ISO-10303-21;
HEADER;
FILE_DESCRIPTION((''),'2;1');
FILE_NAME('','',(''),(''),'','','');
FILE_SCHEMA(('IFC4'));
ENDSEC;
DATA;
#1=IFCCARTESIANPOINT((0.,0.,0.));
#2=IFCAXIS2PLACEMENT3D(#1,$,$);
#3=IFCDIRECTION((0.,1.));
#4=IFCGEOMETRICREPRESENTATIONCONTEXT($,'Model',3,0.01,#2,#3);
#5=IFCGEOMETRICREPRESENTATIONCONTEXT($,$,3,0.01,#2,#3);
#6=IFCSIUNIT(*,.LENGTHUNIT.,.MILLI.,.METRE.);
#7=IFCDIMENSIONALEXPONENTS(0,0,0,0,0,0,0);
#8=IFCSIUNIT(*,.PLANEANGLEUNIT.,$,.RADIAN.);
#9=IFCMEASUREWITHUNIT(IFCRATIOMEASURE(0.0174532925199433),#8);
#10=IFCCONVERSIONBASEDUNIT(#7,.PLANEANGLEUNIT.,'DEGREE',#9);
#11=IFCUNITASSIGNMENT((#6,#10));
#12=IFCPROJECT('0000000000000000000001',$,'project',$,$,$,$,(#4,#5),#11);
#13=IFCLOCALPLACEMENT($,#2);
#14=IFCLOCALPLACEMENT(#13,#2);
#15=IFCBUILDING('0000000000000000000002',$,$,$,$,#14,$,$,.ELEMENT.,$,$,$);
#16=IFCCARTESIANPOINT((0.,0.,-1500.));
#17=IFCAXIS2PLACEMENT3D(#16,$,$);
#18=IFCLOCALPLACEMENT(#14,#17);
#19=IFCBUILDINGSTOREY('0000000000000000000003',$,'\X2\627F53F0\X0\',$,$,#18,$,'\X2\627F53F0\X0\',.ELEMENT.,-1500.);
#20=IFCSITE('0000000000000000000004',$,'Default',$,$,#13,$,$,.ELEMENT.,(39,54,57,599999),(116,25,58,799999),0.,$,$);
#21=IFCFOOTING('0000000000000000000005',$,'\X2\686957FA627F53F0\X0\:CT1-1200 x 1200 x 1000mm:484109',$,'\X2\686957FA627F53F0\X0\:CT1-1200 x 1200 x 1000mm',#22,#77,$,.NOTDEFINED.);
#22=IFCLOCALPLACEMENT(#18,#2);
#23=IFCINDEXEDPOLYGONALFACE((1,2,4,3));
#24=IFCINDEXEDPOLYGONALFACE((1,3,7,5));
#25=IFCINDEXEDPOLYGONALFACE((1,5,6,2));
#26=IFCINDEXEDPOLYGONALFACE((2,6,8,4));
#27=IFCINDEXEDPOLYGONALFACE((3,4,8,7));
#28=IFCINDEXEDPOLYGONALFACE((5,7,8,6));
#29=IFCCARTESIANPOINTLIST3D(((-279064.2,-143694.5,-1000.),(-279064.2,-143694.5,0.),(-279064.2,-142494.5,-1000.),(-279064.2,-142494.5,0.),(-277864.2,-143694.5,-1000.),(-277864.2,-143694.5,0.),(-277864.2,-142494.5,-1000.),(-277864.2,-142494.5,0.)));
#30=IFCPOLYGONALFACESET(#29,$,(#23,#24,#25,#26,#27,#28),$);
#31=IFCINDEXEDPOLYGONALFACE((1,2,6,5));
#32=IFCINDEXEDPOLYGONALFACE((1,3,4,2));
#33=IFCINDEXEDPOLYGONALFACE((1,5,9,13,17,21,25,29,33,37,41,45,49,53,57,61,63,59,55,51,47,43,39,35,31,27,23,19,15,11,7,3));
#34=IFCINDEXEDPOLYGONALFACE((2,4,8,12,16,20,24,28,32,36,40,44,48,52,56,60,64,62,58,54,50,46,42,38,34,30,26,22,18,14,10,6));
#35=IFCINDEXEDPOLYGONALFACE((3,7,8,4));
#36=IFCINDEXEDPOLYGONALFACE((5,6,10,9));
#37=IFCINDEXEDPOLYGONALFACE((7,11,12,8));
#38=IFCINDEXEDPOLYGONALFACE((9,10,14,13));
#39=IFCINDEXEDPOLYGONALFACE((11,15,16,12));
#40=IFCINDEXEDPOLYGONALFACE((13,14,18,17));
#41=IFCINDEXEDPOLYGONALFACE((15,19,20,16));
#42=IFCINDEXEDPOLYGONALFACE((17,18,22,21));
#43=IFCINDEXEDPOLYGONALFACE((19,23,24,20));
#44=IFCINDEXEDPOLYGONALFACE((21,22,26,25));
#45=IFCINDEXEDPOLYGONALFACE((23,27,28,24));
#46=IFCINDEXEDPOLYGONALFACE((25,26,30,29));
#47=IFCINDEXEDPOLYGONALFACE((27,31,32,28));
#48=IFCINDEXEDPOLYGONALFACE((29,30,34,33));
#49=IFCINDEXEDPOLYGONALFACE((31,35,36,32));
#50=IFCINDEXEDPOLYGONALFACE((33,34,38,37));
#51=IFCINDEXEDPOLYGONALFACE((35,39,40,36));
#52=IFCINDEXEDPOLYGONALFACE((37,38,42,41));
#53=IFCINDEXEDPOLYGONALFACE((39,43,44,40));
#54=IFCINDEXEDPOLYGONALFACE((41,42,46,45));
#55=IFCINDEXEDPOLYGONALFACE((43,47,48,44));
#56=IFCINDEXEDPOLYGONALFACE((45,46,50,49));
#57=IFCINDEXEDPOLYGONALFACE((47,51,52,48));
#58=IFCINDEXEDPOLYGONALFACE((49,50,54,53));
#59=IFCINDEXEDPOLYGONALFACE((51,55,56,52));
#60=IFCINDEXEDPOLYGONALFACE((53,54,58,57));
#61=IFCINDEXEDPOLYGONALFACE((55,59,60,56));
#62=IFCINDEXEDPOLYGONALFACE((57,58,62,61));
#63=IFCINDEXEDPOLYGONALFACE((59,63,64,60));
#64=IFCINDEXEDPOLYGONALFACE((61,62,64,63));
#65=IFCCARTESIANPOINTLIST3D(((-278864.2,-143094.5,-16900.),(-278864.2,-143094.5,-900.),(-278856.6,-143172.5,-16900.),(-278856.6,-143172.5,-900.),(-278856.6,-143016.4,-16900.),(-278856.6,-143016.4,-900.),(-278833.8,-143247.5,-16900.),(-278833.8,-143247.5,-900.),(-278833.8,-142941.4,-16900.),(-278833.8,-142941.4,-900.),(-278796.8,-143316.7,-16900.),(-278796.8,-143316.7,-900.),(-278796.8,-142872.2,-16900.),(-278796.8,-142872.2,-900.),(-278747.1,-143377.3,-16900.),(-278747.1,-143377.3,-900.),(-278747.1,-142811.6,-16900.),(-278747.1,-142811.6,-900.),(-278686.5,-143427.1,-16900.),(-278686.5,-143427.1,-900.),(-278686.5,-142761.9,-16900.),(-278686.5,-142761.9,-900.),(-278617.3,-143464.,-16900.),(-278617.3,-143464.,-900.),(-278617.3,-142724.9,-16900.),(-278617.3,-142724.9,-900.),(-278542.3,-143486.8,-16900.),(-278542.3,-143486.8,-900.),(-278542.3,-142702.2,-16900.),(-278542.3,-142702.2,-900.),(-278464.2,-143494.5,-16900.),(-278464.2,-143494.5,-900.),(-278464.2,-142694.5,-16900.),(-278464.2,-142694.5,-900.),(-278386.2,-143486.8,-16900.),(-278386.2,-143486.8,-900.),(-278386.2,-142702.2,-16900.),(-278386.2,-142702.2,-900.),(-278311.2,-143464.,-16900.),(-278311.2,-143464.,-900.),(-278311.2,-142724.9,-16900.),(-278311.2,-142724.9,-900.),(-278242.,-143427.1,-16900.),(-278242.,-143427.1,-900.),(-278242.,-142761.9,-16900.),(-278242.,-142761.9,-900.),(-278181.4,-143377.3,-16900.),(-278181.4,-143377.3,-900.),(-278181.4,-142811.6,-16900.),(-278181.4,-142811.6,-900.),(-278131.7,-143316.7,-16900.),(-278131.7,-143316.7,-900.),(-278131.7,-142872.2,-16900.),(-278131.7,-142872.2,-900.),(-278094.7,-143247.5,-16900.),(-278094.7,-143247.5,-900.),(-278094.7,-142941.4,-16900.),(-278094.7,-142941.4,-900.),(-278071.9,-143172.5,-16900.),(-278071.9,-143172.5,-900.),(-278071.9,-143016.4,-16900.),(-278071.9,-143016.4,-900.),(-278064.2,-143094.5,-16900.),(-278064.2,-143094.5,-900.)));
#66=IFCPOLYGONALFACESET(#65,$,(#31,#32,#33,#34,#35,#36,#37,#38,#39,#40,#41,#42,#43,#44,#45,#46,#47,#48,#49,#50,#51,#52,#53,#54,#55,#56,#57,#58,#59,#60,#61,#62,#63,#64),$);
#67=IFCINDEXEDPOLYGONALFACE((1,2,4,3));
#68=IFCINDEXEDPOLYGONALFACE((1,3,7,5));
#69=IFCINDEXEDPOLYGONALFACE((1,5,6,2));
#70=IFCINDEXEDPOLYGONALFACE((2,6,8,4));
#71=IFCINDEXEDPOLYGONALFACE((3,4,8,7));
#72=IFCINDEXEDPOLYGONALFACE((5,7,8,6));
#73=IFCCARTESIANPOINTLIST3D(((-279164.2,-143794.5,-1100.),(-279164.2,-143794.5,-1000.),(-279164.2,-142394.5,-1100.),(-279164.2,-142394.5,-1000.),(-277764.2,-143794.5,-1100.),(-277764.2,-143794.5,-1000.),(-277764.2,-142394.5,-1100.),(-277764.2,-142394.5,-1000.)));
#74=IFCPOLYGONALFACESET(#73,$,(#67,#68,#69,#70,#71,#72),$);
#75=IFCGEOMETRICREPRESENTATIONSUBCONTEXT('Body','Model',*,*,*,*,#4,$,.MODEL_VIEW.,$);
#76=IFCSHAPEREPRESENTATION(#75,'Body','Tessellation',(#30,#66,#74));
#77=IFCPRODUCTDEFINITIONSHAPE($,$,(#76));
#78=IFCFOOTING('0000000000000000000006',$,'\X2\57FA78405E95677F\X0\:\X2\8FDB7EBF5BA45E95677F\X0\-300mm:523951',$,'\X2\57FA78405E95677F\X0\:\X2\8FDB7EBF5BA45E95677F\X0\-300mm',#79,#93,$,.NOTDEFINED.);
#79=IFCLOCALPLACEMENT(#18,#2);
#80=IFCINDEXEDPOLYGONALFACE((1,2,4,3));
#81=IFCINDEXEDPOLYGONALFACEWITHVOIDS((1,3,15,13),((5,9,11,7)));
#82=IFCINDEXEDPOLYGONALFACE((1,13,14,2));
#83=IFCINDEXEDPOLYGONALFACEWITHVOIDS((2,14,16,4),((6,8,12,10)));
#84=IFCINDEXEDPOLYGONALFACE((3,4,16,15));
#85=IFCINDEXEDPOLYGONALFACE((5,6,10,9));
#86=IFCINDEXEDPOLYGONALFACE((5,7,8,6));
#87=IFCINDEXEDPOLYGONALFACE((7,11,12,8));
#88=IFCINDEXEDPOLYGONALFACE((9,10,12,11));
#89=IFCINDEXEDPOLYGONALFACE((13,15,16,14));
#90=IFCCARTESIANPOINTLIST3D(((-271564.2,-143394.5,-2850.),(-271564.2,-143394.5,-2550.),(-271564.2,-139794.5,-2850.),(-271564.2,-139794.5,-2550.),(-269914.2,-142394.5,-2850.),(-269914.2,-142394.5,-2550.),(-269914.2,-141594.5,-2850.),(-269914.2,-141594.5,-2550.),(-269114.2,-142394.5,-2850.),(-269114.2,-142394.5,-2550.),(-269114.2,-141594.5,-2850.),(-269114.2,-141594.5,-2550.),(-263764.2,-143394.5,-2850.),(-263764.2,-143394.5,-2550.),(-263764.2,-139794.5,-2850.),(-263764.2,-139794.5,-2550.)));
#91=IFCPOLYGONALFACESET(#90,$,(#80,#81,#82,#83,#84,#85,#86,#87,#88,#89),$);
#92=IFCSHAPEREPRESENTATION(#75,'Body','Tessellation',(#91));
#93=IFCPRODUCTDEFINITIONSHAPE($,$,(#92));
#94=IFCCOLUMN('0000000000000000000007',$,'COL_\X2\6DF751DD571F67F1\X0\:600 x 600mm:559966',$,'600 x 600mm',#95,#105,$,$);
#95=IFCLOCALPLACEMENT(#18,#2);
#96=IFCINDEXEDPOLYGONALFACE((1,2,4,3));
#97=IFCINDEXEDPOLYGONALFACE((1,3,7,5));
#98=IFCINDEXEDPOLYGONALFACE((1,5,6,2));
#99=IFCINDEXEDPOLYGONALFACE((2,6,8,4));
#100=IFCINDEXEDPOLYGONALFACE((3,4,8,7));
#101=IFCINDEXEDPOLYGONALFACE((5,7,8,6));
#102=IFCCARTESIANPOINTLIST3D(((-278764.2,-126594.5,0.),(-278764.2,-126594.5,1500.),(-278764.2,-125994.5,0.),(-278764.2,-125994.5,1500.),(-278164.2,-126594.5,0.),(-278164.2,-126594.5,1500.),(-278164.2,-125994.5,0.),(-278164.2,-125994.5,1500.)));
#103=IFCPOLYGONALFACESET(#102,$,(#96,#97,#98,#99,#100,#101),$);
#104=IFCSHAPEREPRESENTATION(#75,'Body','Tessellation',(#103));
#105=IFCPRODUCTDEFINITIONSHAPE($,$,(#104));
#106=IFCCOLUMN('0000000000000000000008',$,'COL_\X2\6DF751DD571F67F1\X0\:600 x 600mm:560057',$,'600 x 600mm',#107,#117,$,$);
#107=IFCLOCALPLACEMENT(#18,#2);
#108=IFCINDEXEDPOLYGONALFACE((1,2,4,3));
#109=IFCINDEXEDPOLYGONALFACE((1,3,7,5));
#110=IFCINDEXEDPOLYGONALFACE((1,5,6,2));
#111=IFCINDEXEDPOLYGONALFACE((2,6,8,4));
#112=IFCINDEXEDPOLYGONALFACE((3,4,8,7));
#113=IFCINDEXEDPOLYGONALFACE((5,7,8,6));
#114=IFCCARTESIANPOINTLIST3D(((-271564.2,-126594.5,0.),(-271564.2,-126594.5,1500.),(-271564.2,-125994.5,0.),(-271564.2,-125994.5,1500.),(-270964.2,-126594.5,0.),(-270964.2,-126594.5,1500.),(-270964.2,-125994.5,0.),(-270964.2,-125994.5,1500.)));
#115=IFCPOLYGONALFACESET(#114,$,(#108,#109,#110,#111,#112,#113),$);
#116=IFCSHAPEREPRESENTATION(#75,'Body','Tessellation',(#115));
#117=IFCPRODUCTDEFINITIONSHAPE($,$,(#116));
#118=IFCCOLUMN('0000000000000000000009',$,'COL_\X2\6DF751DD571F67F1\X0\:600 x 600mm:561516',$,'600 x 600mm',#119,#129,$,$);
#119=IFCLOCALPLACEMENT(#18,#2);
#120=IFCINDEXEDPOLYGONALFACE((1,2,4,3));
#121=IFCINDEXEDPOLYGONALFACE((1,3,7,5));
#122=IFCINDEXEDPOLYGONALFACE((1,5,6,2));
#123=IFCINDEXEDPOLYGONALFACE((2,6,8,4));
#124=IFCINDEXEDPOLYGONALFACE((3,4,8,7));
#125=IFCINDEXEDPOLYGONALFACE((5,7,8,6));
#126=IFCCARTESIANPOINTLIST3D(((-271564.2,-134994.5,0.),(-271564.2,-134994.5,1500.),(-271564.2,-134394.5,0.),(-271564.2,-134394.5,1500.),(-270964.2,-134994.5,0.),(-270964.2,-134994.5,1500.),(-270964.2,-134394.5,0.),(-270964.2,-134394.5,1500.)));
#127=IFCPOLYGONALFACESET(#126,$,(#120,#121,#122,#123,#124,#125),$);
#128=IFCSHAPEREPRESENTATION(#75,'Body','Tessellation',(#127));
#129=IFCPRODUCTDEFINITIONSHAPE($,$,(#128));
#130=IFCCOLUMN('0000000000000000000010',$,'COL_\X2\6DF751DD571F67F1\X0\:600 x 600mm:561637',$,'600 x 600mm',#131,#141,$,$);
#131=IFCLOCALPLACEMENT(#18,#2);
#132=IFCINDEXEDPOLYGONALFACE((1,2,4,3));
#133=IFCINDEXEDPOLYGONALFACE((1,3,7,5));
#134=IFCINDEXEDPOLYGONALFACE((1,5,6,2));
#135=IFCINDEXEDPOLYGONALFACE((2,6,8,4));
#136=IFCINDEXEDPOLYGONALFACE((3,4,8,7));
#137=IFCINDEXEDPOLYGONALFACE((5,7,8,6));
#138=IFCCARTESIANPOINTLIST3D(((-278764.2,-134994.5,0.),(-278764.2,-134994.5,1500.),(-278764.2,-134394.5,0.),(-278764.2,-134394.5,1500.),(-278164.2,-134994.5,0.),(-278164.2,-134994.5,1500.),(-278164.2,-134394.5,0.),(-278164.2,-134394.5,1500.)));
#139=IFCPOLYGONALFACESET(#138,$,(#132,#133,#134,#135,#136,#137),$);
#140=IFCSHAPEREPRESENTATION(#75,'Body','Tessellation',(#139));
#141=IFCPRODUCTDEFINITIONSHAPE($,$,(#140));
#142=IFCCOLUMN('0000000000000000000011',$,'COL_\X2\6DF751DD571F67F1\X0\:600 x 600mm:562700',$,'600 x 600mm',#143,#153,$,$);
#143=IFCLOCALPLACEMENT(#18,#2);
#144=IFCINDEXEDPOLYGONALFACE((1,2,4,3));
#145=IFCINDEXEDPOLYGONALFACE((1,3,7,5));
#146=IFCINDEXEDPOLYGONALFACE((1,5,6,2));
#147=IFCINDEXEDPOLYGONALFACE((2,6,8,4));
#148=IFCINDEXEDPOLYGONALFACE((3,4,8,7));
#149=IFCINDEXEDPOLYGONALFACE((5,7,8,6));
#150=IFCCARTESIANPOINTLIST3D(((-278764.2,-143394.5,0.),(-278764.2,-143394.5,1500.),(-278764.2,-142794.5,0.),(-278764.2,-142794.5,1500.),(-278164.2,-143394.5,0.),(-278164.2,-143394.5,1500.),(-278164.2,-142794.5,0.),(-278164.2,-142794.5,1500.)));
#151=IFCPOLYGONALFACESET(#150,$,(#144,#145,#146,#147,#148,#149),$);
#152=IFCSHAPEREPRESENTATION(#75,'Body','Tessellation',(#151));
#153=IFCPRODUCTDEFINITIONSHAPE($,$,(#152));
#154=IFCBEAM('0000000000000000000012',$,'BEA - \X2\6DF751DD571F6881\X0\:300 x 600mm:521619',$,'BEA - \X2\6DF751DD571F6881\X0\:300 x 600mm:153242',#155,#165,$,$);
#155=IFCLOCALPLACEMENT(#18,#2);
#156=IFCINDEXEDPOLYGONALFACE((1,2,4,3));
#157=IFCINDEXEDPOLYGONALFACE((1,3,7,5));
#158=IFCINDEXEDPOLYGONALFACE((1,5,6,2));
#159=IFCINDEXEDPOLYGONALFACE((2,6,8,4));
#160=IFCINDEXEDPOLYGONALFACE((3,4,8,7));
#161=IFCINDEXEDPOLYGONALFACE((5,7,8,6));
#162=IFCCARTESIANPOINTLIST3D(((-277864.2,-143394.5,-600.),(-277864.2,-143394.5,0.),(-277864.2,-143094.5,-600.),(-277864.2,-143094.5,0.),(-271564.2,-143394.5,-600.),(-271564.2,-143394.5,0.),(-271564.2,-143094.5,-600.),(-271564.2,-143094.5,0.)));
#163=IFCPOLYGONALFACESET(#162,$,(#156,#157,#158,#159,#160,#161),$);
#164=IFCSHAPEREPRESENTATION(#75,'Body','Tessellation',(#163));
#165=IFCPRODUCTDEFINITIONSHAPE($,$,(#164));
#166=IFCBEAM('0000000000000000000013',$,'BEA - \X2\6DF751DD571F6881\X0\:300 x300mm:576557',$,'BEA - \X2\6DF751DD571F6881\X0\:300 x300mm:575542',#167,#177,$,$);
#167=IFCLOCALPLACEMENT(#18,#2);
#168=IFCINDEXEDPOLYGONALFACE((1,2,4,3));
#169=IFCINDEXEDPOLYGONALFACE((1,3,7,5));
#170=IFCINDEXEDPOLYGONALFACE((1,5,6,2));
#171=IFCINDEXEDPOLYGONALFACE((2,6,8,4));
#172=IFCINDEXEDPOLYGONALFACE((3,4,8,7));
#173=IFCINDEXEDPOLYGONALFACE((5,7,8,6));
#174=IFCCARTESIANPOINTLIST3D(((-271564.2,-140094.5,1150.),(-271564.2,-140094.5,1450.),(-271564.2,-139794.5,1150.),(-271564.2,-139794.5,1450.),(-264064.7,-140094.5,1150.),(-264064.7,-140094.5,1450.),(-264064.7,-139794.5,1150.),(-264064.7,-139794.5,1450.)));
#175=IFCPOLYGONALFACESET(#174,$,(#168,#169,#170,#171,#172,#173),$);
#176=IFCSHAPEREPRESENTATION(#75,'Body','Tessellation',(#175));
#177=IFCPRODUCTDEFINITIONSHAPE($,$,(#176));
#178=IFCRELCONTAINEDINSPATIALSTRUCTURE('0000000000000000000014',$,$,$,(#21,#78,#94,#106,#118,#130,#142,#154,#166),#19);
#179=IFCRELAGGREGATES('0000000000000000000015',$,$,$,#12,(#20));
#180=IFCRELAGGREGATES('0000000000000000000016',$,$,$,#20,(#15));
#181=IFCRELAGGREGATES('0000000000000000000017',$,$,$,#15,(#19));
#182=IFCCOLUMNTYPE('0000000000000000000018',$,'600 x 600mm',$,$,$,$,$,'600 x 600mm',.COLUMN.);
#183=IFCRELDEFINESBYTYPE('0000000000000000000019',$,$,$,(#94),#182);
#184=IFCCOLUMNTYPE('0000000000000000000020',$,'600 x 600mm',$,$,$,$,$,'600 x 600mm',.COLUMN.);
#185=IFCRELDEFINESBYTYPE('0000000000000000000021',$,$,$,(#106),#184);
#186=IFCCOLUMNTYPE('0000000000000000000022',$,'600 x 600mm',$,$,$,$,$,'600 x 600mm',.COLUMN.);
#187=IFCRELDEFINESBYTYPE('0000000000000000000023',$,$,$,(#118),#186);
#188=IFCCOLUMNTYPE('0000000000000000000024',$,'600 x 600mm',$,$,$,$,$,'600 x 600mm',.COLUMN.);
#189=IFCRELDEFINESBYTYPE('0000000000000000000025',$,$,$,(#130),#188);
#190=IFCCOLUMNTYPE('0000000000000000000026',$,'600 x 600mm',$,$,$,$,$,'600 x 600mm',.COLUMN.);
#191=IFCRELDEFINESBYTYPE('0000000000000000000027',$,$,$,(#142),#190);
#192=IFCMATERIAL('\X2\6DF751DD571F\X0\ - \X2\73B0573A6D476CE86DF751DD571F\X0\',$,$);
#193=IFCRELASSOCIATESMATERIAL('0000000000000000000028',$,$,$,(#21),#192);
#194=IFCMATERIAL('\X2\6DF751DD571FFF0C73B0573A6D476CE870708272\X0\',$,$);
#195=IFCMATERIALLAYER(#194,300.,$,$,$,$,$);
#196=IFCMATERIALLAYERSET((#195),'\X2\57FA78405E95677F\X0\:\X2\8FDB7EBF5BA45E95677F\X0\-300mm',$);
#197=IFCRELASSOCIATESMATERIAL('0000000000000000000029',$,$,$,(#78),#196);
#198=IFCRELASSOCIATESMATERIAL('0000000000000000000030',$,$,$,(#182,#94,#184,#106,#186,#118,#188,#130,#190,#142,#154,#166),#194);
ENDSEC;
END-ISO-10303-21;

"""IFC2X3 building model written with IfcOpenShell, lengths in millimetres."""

from ifc_helpers import new_model, entity, si_unit, converted_unit, direction, frame, frame_2d, origin, origin_2d_with_axis, place, context, subcontext, project, spatial, rectangle, circle, extrude, source, transform, mapped, material, layer, layer_set, layer_usage, type_object, type_shapes, element, save


model = new_model("IFC2X3")

# Units and contexts
model_context = context("Model", 3, precision=0.01, world=origin(), true_north=direction((0.0, 1.0)))
context_of_model = context(None, 3, precision=0.01, world=origin(), true_north=direction((0.0, 1.0)))
body_context = subcontext(model_context, "Body", "Model", "MODEL_VIEW")
ifc_project = project(units=[si_unit("LENGTHUNIT", "METRE", prefix="MILLI"), converted_unit("PLANEANGLEUNIT", "DEGREE", entity("IfcRatioMeasure", 0.0174532925199433), si_unit("PLANEANGLEUNIT", "RADIAN"), dimensions=[0, 0, 0, 0, 0, 0, 0])], contexts=[model_context, context_of_model])

# Site, building, storey
site_placement = place(None, origin())
site = spatial("IfcSite", under=ifc_project, at=site_placement, Name="Default", CompositionType="ELEMENT", RefLatitude=(39, 54, 57, 599999), RefLongitude=(116, 25, 58, 799999), RefElevation=0.0)
building_placement = place(site_placement, origin())
building = spatial("IfcBuilding", under=site, at=building_placement, CompositionType="ELEMENT")
storey_placement = place(building_placement, frame((0.0, 0.0, -1500.0)))
storey = spatial("IfcBuildingStorey", under=building, at=storey_placement, Name="承台", LongName="承台", CompositionType="ELEMENT", Elevation=-1500.0)

# Footing
ifc_material_1 = material(Name="混凝土 - 现场浇注混凝土")
footing_1_placement = place(storey_placement, frame((-279164.2, -143794.5, -16900.0)))
element("IfcFooting", 1, at=footing_1_placement, inside=storey, material=ifc_material_1, Name="桩基承台:CT1-1200 x 1200 x 1000mm:484109", ObjectType="桩基承台:CT1-1200 x 1200 x 1000mm", PredefinedType="NOTDEFINED", context=body_context, shape_type="SweptSolid", body=[
    extrude(rectangle(XDim=1200.0, YDim=1200.0, at=origin_2d_with_axis()), frame((700.0, 700.0, 15900.0), z_axis=(0.0, 0.0, 1.0), x_axis=(-1.0, 0.0, 0.0)), (0.0, 0.0, 1.0), 1000.0),
    extrude(circle(Radius=400.0, at=origin_2d_with_axis()), frame((700.0, 700.0, 0.0)), (0.0, 0.0, 1.0), 16000.0),
    extrude(rectangle(XDim=1400.0, YDim=1400.0, at=frame_2d((0.0, 0.0), x_axis=(1.0, 0.0))), frame((700.0, 700.0, 15800.0), z_axis=(0.0, 0.0, 1.0), x_axis=(0.0, 1.0, 0.0)), (0.0, 0.0, 1.0), 100.0),
])

# Footing, opening
ifc_material_2 = material(Name="混凝土，现场浇注灰色")
ifc_layer_1 = layer(ifc_material_2, 300.0)
ifc_layer_set_1 = layer_set([ifc_layer_1], Name="基础底板:进线室底板-300mm")
ifc_layer_usage_1 = layer_usage(ifc_layer_set_1, "AXIS3", "POSITIVE", 0.0)
footing_2_placement = place(storey_placement, frame((-271564.2, -143394.5, -2850.0)))
footing_2 = element("IfcFooting", 2, at=footing_2_placement, inside=storey, material=ifc_layer_usage_1, Name="基础底板:进线室底板-300mm:523951", ObjectType="基础底板:进线室底板-300mm", PredefinedType="NOTDEFINED", context=body_context, shape_type="SweptSolid", body=[
    extrude(rectangle(XDim=7800.0, YDim=3600.0, at=frame_2d((0.0, 0.0), x_axis=(-1.0, 0.0))), frame((3900.0, 1800.0, 300.0), z_axis=(0.0, 0.0, -1.0), x_axis=(-1.0, 0.0, 0.0)), (0.0, 0.0, 1.0), 300.0),
])
opening_placement = place(footing_2_placement, frame((2050.0, 1400.0, 300.0)))
element("IfcOpeningElement", 3, at=opening_placement, cuts=footing_2, ObjectType="Opening", context=body_context, shape_type="SweptSolid", body=[
    extrude(rectangle(XDim=800.0, YDim=800.0, at=origin_2d_with_axis()), frame((0.0, 0.0, 0.0), z_axis=(0.0, 0.0, -1.0), x_axis=(0.0, -1.0, 0.0)), (0.0, 0.0, 1.0), 300.0),
])

# Columns
column_type_1 = type_object("IfcColumnType", Name="600 x 600mm", ElementType="600 x 600mm", PredefinedType="COLUMN", material=ifc_material_2)
shared_shape_1 = source(origin(), body_context, "Body", "SweptSolid", [
    extrude(rectangle(XDim=600.0, YDim=600.0, at=origin_2d_with_axis()), frame((300.0, 300.0, 0.0), z_axis=(0.0, 0.0, 1.0), x_axis=(-1.0, 0.0, 0.0)), (0.0, 0.0, 1.0), 1500.0),
])
type_shapes(column_type_1, [shared_shape_1])
column_1_placement = place(storey_placement, frame((-278764.2, -126594.5, 0.0)))
element("IfcColumn", 4, at=column_1_placement, inside=storey, type_object=column_type_1, material=ifc_material_2, Name="COL_混凝土柱:600 x 600mm:559966", ObjectType="600 x 600mm", context=body_context, shape_type="MappedRepresentation", body=[
    mapped(shared_shape_1, transform((0.0, 0.0, 0.0), scale=1.0)),
])
column_type_2 = type_object("IfcColumnType", Name="600 x 600mm", ElementType="600 x 600mm", PredefinedType="COLUMN", material=ifc_material_2)
shared_shape_2 = source(origin(), body_context, "Body", "SweptSolid", [
    extrude(rectangle(XDim=600.0, YDim=600.0, at=origin_2d_with_axis()), frame((300.0, 300.0, 0.0), z_axis=(0.0, 0.0, 1.0), x_axis=(-1.0, 0.0, 0.0)), (0.0, 0.0, 1.0), 1500.0),
])
type_shapes(column_type_2, [shared_shape_2])
column_2_placement = place(storey_placement, frame((-271564.2, -126594.5, 0.0)))
element("IfcColumn", 5, at=column_2_placement, inside=storey, type_object=column_type_2, material=ifc_material_2, Name="COL_混凝土柱:600 x 600mm:560057", ObjectType="600 x 600mm", context=body_context, shape_type="MappedRepresentation", body=[
    mapped(shared_shape_2, transform((0.0, 0.0, 0.0), scale=1.0)),
])
column_type_3 = type_object("IfcColumnType", Name="600 x 600mm", ElementType="600 x 600mm", PredefinedType="COLUMN", material=ifc_material_2)
shared_shape_3 = source(origin(), body_context, "Body", "SweptSolid", [
    extrude(rectangle(XDim=600.0, YDim=600.0, at=origin_2d_with_axis()), frame((300.0, 300.0, 0.0), z_axis=(0.0, 0.0, 1.0), x_axis=(-1.0, 0.0, 0.0)), (0.0, 0.0, 1.0), 1500.0),
])
type_shapes(column_type_3, [shared_shape_3])
column_3_placement = place(storey_placement, frame((-271564.2, -134994.5, 0.0)))
element("IfcColumn", 6, at=column_3_placement, inside=storey, type_object=column_type_3, material=ifc_material_2, Name="COL_混凝土柱:600 x 600mm:561516", ObjectType="600 x 600mm", context=body_context, shape_type="MappedRepresentation", body=[
    mapped(shared_shape_3, transform((0.0, 0.0, 0.0), scale=1.0)),
])
column_type_4 = type_object("IfcColumnType", Name="600 x 600mm", ElementType="600 x 600mm", PredefinedType="COLUMN", material=ifc_material_2)
shared_shape_4 = source(origin(), body_context, "Body", "SweptSolid", [
    extrude(rectangle(XDim=600.0, YDim=600.0, at=origin_2d_with_axis()), frame((300.0, 300.0, 0.0), z_axis=(0.0, 0.0, 1.0), x_axis=(-1.0, 0.0, 0.0)), (0.0, 0.0, 1.0), 1500.0),
])
type_shapes(column_type_4, [shared_shape_4])
column_4_placement = place(storey_placement, frame((-278764.2, -134994.5, 0.0)))
element("IfcColumn", 7, at=column_4_placement, inside=storey, type_object=column_type_4, material=ifc_material_2, Name="COL_混凝土柱:600 x 600mm:561637", ObjectType="600 x 600mm", context=body_context, shape_type="MappedRepresentation", body=[
    mapped(shared_shape_4, transform((0.0, 0.0, 0.0), scale=1.0)),
])
column_type_5 = type_object("IfcColumnType", Name="600 x 600mm", ElementType="600 x 600mm", PredefinedType="COLUMN", material=ifc_material_2)
shared_shape_5 = source(origin(), body_context, "Body", "SweptSolid", [
    extrude(rectangle(XDim=600.0, YDim=600.0, at=origin_2d_with_axis()), frame((300.0, 300.0, 0.0), z_axis=(0.0, 0.0, 1.0), x_axis=(-1.0, 0.0, 0.0)), (0.0, 0.0, 1.0), 1500.0),
])
type_shapes(column_type_5, [shared_shape_5])
column_5_placement = place(storey_placement, frame((-278764.2, -143394.5, 0.0)))
element("IfcColumn", 8, at=column_5_placement, inside=storey, type_object=column_type_5, material=ifc_material_2, Name="COL_混凝土柱:600 x 600mm:562700", ObjectType="600 x 600mm", context=body_context, shape_type="MappedRepresentation", body=[
    mapped(shared_shape_5, transform((0.0, 0.0, 0.0), scale=1.0)),
])

# Beams
beam_1_placement = place(storey_placement, frame((-271564.2, -143244.5, 0.0), z_axis=(0.0, 0.0, 1.0), x_axis=(-1.0, 0.0, 0.0)))
element("IfcBeam", 9, at=beam_1_placement, inside=storey, material=ifc_material_2, Name="BEA - 混凝土梁:300 x 600mm:521619", ObjectType="BEA - 混凝土梁:300 x 600mm:153242", context=body_context, shape_type="SweptSolid", body=[
    extrude(rectangle(XDim=600.0, YDim=300.0, at=frame_2d((0.0, 0.0), x_axis=(1.0, 0.0))), frame((0.0, 0.0, -300.0), z_axis=(1.0, 0.0, 0.0), x_axis=(0.0, 0.0, -1.0)), (0.0, 0.0, 1.0), 6300.0),
])
beam_2_placement = place(storey_placement, frame((-271414.2, -139944.5, 1450.0)))
element("IfcBeam", 10, at=beam_2_placement, inside=storey, material=ifc_material_2, Name="BEA - 混凝土梁:300 x300mm:576557", ObjectType="BEA - 混凝土梁:300 x300mm:575542", context=body_context, shape_type="SweptSolid", body=[
    extrude(rectangle(XDim=300.0, YDim=300.0, at=frame_2d((0.0, 0.0), x_axis=(1.0, 0.0))), frame((-150.0, 0.0, -150.0), z_axis=(1.0, 0.0, 0.0), x_axis=(0.0, 0.0, -1.0)), (0.0, 0.0, 1.0), 7499.5),
])

save(model, "model.ifc")
